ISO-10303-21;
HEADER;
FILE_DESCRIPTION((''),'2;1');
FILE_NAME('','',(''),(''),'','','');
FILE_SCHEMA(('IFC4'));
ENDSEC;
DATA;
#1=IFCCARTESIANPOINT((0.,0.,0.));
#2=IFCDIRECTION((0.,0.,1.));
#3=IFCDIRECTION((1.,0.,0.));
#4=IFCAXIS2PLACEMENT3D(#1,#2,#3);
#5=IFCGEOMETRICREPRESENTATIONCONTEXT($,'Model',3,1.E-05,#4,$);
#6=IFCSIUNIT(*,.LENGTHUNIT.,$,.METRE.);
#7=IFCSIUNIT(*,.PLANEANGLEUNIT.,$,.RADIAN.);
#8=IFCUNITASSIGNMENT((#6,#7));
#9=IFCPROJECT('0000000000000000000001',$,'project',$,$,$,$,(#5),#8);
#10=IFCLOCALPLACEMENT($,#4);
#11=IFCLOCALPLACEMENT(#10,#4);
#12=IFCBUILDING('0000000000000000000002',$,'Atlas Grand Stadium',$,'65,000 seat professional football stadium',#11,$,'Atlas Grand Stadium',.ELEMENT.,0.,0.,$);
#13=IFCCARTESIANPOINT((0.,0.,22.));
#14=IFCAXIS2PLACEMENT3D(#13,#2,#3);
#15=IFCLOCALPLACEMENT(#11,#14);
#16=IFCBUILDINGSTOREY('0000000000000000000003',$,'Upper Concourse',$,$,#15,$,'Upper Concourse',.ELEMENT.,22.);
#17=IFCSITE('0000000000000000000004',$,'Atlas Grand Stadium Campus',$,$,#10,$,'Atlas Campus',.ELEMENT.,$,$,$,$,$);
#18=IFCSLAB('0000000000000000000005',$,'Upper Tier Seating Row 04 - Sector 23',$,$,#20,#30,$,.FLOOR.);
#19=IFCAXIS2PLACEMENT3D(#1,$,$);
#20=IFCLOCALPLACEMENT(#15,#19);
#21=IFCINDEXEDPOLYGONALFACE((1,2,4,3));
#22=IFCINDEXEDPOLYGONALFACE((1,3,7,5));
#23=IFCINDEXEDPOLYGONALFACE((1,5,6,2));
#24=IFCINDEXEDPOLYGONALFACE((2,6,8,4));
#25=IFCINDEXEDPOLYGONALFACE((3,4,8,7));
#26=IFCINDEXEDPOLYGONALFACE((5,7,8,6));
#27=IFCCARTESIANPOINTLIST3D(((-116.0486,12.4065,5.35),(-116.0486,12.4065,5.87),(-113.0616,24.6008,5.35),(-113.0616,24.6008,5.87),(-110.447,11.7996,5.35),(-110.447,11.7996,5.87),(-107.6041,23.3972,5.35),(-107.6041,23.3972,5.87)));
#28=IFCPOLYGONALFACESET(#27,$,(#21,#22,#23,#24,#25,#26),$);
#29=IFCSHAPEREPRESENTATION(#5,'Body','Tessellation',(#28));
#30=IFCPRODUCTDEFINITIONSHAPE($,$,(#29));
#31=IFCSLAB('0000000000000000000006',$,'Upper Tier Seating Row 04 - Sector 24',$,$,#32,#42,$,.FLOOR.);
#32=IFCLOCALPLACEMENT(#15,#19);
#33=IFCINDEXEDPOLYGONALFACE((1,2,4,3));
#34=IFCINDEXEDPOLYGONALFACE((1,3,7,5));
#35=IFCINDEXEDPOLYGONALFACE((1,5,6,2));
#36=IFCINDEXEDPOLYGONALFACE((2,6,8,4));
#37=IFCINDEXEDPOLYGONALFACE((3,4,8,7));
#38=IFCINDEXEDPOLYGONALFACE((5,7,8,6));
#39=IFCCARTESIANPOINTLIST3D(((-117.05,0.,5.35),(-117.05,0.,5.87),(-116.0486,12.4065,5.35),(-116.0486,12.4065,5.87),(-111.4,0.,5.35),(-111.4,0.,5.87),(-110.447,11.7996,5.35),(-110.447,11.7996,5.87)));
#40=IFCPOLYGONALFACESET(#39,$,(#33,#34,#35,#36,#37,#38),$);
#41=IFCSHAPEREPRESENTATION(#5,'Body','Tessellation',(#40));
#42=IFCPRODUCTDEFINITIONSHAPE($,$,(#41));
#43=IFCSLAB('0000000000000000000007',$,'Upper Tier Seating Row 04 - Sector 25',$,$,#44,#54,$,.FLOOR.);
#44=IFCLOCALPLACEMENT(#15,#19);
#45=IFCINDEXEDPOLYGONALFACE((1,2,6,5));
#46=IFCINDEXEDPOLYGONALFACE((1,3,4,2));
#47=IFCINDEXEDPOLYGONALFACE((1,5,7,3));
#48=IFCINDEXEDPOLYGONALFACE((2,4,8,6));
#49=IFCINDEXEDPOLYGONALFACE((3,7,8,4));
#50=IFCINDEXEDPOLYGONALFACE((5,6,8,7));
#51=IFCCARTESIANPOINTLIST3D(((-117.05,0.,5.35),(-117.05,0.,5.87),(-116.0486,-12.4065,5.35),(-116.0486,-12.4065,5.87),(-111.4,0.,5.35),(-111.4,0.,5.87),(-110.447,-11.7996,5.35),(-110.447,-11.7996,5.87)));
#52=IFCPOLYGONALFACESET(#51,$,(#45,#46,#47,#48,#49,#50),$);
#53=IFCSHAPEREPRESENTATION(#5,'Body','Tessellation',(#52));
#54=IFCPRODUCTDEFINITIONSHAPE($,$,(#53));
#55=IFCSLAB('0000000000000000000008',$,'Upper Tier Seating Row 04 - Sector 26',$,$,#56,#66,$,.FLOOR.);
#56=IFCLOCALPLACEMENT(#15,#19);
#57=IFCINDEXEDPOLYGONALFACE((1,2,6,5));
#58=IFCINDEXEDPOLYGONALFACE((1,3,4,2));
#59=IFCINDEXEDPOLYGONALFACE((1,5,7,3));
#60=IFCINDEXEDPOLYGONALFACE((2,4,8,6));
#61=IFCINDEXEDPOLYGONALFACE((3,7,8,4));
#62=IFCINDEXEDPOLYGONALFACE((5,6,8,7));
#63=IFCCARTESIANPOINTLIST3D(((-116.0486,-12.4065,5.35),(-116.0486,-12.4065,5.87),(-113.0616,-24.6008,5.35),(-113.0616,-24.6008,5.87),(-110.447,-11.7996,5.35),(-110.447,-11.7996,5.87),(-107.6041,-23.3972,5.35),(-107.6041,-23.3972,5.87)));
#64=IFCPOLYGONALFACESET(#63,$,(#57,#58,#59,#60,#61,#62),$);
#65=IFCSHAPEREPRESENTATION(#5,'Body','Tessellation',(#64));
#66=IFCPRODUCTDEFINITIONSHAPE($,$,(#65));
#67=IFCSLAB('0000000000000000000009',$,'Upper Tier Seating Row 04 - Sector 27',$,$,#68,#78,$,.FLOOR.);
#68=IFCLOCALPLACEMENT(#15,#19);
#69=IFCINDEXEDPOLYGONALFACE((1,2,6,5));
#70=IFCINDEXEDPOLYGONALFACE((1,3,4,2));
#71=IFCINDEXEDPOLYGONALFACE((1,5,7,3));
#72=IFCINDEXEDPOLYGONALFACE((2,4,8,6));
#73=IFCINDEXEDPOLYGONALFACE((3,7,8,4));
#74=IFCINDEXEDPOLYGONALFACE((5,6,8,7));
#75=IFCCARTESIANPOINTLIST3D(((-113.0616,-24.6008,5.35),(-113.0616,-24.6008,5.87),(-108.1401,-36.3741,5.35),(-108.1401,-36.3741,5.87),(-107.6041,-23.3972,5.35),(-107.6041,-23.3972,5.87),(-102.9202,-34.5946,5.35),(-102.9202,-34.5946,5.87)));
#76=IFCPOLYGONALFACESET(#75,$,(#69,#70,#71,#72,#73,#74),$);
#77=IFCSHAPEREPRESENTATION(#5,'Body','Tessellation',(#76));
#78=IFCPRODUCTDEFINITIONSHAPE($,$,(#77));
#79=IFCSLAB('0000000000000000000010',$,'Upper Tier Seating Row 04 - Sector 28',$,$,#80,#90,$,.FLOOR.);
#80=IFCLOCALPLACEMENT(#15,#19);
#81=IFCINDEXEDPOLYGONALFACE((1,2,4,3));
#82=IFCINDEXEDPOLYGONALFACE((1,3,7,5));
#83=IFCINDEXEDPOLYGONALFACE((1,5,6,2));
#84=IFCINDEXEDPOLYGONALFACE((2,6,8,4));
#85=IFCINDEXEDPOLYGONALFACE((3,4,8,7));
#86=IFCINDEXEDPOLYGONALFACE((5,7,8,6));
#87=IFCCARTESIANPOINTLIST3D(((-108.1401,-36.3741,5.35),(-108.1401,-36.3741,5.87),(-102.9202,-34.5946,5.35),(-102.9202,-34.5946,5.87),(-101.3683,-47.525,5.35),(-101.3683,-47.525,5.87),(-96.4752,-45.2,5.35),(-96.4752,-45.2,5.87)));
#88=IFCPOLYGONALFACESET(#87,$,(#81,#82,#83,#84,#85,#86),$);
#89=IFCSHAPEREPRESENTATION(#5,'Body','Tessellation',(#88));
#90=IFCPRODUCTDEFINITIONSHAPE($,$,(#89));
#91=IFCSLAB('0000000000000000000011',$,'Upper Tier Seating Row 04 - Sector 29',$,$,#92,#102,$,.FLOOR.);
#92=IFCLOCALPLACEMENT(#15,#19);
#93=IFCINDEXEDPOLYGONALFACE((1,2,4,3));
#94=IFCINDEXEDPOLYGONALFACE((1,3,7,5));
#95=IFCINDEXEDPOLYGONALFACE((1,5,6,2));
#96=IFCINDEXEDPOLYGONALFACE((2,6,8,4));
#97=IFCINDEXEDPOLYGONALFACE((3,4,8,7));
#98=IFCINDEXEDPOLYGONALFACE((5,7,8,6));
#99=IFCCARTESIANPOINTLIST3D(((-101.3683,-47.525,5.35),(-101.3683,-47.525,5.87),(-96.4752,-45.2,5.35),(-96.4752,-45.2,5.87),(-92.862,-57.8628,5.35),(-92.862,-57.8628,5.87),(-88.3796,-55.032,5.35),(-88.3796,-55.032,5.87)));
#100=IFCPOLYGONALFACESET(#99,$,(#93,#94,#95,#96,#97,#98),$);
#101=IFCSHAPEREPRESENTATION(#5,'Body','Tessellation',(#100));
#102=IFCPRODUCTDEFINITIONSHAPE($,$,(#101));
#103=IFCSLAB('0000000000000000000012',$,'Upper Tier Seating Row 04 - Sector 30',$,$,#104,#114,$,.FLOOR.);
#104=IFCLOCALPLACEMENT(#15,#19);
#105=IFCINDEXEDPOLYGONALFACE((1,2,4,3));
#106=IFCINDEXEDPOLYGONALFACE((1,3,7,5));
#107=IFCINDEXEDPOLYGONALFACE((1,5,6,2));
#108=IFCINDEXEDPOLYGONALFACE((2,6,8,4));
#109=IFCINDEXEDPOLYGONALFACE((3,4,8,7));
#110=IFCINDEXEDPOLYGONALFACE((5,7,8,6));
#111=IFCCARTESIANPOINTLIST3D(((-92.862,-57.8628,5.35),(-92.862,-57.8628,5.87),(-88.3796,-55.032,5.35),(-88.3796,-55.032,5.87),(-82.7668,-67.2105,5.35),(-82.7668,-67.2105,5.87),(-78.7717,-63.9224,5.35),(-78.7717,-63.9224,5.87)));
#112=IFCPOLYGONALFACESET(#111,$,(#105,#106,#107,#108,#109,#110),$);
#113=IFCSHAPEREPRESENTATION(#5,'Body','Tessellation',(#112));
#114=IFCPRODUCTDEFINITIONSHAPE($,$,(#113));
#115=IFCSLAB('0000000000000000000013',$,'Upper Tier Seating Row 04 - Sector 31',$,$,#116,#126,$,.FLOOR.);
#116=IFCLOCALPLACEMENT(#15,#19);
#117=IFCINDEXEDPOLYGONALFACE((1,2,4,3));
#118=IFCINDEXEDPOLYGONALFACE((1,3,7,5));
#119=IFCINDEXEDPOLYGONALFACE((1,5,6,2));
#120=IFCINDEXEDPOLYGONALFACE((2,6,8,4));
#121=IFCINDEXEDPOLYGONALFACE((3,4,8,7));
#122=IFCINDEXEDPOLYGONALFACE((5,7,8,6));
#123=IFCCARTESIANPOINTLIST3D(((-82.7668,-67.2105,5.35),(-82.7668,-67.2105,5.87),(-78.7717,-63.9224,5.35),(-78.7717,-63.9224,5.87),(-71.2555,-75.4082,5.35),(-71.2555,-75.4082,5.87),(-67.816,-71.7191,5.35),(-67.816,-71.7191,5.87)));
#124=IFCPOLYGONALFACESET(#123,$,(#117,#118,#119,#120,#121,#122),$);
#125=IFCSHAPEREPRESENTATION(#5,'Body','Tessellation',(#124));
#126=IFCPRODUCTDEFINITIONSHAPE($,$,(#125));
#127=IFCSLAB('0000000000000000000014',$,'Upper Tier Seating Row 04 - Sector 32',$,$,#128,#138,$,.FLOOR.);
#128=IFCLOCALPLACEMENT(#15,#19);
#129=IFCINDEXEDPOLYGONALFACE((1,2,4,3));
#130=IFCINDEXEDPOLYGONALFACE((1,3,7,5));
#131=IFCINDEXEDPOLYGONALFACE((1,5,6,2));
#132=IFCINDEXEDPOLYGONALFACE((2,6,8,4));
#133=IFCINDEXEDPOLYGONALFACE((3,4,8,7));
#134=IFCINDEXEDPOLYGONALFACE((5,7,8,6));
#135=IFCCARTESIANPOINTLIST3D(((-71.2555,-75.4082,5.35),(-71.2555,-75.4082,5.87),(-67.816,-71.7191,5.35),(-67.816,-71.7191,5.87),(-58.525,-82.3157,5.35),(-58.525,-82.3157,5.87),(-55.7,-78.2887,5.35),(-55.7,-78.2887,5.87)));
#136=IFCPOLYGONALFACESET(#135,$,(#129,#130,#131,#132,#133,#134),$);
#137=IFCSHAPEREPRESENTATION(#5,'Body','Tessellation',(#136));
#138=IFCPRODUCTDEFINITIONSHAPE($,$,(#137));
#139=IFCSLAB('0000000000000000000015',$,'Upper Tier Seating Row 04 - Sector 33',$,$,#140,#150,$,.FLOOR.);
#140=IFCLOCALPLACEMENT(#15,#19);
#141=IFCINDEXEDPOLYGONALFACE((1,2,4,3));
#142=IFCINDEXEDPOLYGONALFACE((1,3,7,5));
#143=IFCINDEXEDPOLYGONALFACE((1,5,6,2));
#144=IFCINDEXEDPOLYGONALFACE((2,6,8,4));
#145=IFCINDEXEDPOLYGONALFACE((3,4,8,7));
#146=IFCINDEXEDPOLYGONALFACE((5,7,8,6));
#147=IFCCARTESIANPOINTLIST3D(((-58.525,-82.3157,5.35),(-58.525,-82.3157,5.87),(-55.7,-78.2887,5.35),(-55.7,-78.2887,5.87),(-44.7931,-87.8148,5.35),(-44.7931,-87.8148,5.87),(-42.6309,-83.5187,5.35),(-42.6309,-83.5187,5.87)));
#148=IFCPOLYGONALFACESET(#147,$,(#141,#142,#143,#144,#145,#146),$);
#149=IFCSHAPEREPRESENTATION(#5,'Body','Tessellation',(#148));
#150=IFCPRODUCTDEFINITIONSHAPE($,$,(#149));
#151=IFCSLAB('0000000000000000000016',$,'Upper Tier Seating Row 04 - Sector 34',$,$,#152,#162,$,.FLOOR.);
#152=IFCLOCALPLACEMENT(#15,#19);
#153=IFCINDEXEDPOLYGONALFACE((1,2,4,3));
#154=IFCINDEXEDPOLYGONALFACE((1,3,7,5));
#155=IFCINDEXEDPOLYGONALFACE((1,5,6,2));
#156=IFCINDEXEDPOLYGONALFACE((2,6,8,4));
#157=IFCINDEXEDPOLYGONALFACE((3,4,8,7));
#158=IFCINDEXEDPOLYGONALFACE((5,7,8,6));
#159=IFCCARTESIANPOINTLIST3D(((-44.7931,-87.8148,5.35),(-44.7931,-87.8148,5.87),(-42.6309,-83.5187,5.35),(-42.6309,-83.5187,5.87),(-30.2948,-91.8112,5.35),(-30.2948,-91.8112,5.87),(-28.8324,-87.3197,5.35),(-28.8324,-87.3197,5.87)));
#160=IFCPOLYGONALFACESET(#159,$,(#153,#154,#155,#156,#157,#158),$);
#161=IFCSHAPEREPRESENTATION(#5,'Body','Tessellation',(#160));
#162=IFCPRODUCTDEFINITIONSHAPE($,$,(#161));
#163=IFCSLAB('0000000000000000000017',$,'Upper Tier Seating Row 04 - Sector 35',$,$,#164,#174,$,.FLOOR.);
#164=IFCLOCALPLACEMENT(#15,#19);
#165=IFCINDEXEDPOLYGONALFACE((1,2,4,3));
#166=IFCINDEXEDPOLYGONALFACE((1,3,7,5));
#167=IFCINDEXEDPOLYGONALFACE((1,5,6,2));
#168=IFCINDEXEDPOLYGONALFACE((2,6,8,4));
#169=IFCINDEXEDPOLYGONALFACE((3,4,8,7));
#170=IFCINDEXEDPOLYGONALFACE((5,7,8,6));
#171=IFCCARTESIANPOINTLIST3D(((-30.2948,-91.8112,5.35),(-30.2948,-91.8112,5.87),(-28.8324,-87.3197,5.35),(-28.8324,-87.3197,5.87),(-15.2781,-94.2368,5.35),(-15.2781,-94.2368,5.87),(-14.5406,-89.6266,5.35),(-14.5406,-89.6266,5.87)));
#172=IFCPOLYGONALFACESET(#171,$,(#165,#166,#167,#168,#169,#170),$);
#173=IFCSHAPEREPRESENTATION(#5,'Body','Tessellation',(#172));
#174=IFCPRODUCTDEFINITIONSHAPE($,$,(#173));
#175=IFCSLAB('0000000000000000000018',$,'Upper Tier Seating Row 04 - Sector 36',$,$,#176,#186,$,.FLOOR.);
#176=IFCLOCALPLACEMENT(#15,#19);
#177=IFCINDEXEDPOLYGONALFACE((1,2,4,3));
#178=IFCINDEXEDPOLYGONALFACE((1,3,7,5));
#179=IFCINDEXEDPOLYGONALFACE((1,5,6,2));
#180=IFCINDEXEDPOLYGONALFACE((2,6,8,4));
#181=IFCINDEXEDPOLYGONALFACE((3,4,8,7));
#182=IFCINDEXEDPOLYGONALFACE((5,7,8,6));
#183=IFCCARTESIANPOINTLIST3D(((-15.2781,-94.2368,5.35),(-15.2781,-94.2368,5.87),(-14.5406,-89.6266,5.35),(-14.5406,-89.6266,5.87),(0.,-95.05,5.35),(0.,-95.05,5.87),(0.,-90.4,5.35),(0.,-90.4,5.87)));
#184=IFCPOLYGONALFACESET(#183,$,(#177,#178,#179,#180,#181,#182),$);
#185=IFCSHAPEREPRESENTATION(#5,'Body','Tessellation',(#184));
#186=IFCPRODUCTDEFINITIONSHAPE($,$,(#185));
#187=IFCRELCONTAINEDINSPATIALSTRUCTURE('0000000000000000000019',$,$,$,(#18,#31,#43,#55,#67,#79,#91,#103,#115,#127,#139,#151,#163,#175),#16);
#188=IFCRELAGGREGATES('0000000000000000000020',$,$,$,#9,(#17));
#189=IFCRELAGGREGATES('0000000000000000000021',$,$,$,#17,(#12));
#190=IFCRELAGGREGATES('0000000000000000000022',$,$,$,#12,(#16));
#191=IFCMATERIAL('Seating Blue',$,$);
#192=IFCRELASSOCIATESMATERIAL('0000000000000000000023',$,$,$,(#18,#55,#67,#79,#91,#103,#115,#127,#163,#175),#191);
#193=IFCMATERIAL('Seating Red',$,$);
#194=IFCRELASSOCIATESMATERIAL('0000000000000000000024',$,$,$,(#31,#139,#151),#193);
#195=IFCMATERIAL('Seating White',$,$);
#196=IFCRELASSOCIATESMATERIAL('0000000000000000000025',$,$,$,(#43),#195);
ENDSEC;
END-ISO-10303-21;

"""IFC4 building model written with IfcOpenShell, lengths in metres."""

from ifc_helpers import new_model, si_unit, frame, origin_with_axes, place, context, project, spatial, polyline, outline, extrude, material, element, save


model = new_model("IFC4")

# Units and contexts
model_context = context("Model", 3, precision=1e-05, world=origin_with_axes())
ifc_project = project(units=[si_unit("LENGTHUNIT", "METRE"), si_unit("PLANEANGLEUNIT", "RADIAN")], contexts=[model_context])

# Site, building, storey
site_placement = place(None, origin_with_axes())
site = spatial("IfcSite", under=ifc_project, at=site_placement, Name="Atlas Grand Stadium Campus", LongName="Atlas Campus", CompositionType="ELEMENT")
building_placement = place(site_placement, origin_with_axes())
building = spatial("IfcBuilding", under=site, at=building_placement, Name="Atlas Grand Stadium", ObjectType="65,000 seat professional football stadium", LongName="Atlas Grand Stadium", CompositionType="ELEMENT", ElevationOfRefHeight=0.0, ElevationOfTerrain=0.0)
storey_placement = place(building_placement, frame((0.0, 0.0, 22.0), z_axis=(0.0, 0.0, 1.0), x_axis=(1.0, 0.0, 0.0)))
storey = spatial("IfcBuildingStorey", under=building, at=storey_placement, Name="Upper Concourse", LongName="Upper Concourse", CompositionType="ELEMENT", Elevation=22.0)

# Slabs
ifc_material_1 = material(Name="Seating Blue")
slab_1_placement = place(storey_placement, frame((0.0, 0.0, 5.35), z_axis=(0.0, 0.0, 1.0), x_axis=(1.0, 0.0, 0.0)))
element("IfcSlab", 1, at=slab_1_placement, inside=storey, material=ifc_material_1, Name="Upper Tier Seating Row 04 - Sector 23", PredefinedType="FLOOR", context=model_context, shape_type="SweptSolid", body=[
    extrude(outline(polyline([(-113.0616, 24.6008), (-116.0486, 12.4065), (-110.447, 11.7996), (-107.6041, 23.3972), (-113.0616, 24.6008)])), origin_with_axes(), (0.0, 0.0, 1.0), 0.52),
])
ifc_material_2 = material(Name="Seating Red")
slab_2_placement = place(storey_placement, frame((0.0, 0.0, 5.35), z_axis=(0.0, 0.0, 1.0), x_axis=(1.0, 0.0, 0.0)))
element("IfcSlab", 2, at=slab_2_placement, inside=storey, material=ifc_material_2, Name="Upper Tier Seating Row 04 - Sector 24", PredefinedType="FLOOR", context=model_context, shape_type="SweptSolid", body=[
    extrude(outline(polyline([(-116.0486, 12.4065), (-117.05, 0.0), (-111.4, 0.0), (-110.447, 11.7996), (-116.0486, 12.4065)])), origin_with_axes(), (0.0, 0.0, 1.0), 0.52),
])
ifc_material_3 = material(Name="Seating White")
slab_3_placement = place(storey_placement, frame((0.0, 0.0, 5.35), z_axis=(0.0, 0.0, 1.0), x_axis=(1.0, 0.0, 0.0)))
element("IfcSlab", 3, at=slab_3_placement, inside=storey, material=ifc_material_3, Name="Upper Tier Seating Row 04 - Sector 25", PredefinedType="FLOOR", context=model_context, shape_type="SweptSolid", body=[
    extrude(outline(polyline([(-117.05, 0.0), (-116.0486, -12.4065), (-110.447, -11.7996), (-111.4, 0.0), (-117.05, 0.0)])), origin_with_axes(), (0.0, 0.0, 1.0), 0.52),
])
slab_4_placement = place(storey_placement, frame((0.0, 0.0, 5.35), z_axis=(0.0, 0.0, 1.0), x_axis=(1.0, 0.0, 0.0)))
element("IfcSlab", 4, at=slab_4_placement, inside=storey, material=ifc_material_1, Name="Upper Tier Seating Row 04 - Sector 26", PredefinedType="FLOOR", context=model_context, shape_type="SweptSolid", body=[
    extrude(outline(polyline([(-116.0486, -12.4065), (-113.0616, -24.6008), (-107.6041, -23.3972), (-110.447, -11.7996), (-116.0486, -12.4065)])), origin_with_axes(), (0.0, 0.0, 1.0), 0.52),
])
slab_5_placement = place(storey_placement, frame((0.0, 0.0, 5.35), z_axis=(0.0, 0.0, 1.0), x_axis=(1.0, 0.0, 0.0)))
element("IfcSlab", 5, at=slab_5_placement, inside=storey, material=ifc_material_1, Name="Upper Tier Seating Row 04 - Sector 27", PredefinedType="FLOOR", context=model_context, shape_type="SweptSolid", body=[
    extrude(outline(polyline([(-113.0616, -24.6008), (-108.1401, -36.3741), (-102.9202, -34.5946), (-107.6041, -23.3972), (-113.0616, -24.6008)])), origin_with_axes(), (0.0, 0.0, 1.0), 0.52),
])
slab_6_placement = place(storey_placement, frame((0.0, 0.0, 5.35), z_axis=(0.0, 0.0, 1.0), x_axis=(1.0, 0.0, 0.0)))
element("IfcSlab", 6, at=slab_6_placement, inside=storey, material=ifc_material_1, Name="Upper Tier Seating Row 04 - Sector 28", PredefinedType="FLOOR", context=model_context, shape_type="SweptSolid", body=[
    extrude(outline(polyline([(-108.1401, -36.3741), (-101.3683, -47.525), (-96.4752, -45.2), (-102.9202, -34.5946), (-108.1401, -36.3741)])), origin_with_axes(), (0.0, 0.0, 1.0), 0.52),
])
slab_7_placement = place(storey_placement, frame((0.0, 0.0, 5.35), z_axis=(0.0, 0.0, 1.0), x_axis=(1.0, 0.0, 0.0)))
element("IfcSlab", 7, at=slab_7_placement, inside=storey, material=ifc_material_1, Name="Upper Tier Seating Row 04 - Sector 29", PredefinedType="FLOOR", context=model_context, shape_type="SweptSolid", body=[
    extrude(outline(polyline([(-101.3683, -47.525), (-92.862, -57.8628), (-88.3796, -55.032), (-96.4752, -45.2), (-101.3683, -47.525)])), origin_with_axes(), (0.0, 0.0, 1.0), 0.52),
])
slab_8_placement = place(storey_placement, frame((0.0, 0.0, 5.35), z_axis=(0.0, 0.0, 1.0), x_axis=(1.0, 0.0, 0.0)))
element("IfcSlab", 8, at=slab_8_placement, inside=storey, material=ifc_material_1, Name="Upper Tier Seating Row 04 - Sector 30", PredefinedType="FLOOR", context=model_context, shape_type="SweptSolid", body=[
    extrude(outline(polyline([(-92.862, -57.8628), (-82.7669, -67.2105), (-78.7717, -63.9224), (-88.3796, -55.032), (-92.862, -57.8628)])), origin_with_axes(), (0.0, 0.0, 1.0), 0.52),
])
slab_9_placement = place(storey_placement, frame((0.0, 0.0, 5.35), z_axis=(0.0, 0.0, 1.0), x_axis=(1.0, 0.0, 0.0)))
element("IfcSlab", 9, at=slab_9_placement, inside=storey, material=ifc_material_1, Name="Upper Tier Seating Row 04 - Sector 31", PredefinedType="FLOOR", context=model_context, shape_type="SweptSolid", body=[
    extrude(outline(polyline([(-82.7669, -67.2105), (-71.2555, -75.4082), (-67.816, -71.7191), (-78.7717, -63.9224), (-82.7669, -67.2105)])), origin_with_axes(), (0.0, 0.0, 1.0), 0.52),
])
slab_10_placement = place(storey_placement, frame((0.0, 0.0, 5.35), z_axis=(0.0, 0.0, 1.0), x_axis=(1.0, 0.0, 0.0)))
element("IfcSlab", 10, at=slab_10_placement, inside=storey, material=ifc_material_1, Name="Upper Tier Seating Row 04 - Sector 32", PredefinedType="FLOOR", context=model_context, shape_type="SweptSolid", body=[
    extrude(outline(polyline([(-71.2555, -75.4082), (-58.525, -82.3157), (-55.7, -78.2887), (-67.816, -71.7191), (-71.2555, -75.4082)])), origin_with_axes(), (0.0, 0.0, 1.0), 0.52),
])
slab_11_placement = place(storey_placement, frame((0.0, 0.0, 5.35), z_axis=(0.0, 0.0, 1.0), x_axis=(1.0, 0.0, 0.0)))
element("IfcSlab", 11, at=slab_11_placement, inside=storey, material=ifc_material_2, Name="Upper Tier Seating Row 04 - Sector 33", PredefinedType="FLOOR", context=model_context, shape_type="SweptSolid", body=[
    extrude(outline(polyline([(-58.525, -82.3157), (-44.7931, -87.8148), (-42.6309, -83.5187), (-55.7, -78.2887), (-58.525, -82.3157)])), origin_with_axes(), (0.0, 0.0, 1.0), 0.52),
])
slab_12_placement = place(storey_placement, frame((0.0, 0.0, 5.35), z_axis=(0.0, 0.0, 1.0), x_axis=(1.0, 0.0, 0.0)))
element("IfcSlab", 12, at=slab_12_placement, inside=storey, material=ifc_material_2, Name="Upper Tier Seating Row 04 - Sector 34", PredefinedType="FLOOR", context=model_context, shape_type="SweptSolid", body=[
    extrude(outline(polyline([(-44.7931, -87.8148), (-30.2948, -91.8113), (-28.8324, -87.3197), (-42.6309, -83.5187), (-44.7931, -87.8148)])), origin_with_axes(), (0.0, 0.0, 1.0), 0.52),
])
slab_13_placement = place(storey_placement, frame((0.0, 0.0, 5.35), z_axis=(0.0, 0.0, 1.0), x_axis=(1.0, 0.0, 0.0)))
element("IfcSlab", 13, at=slab_13_placement, inside=storey, material=ifc_material_1, Name="Upper Tier Seating Row 04 - Sector 35", PredefinedType="FLOOR", context=model_context, shape_type="SweptSolid", body=[
    extrude(outline(polyline([(-30.2948, -91.8113), (-15.2781, -94.2368), (-14.5406, -89.6266), (-28.8324, -87.3197), (-30.2948, -91.8113)])), origin_with_axes(), (0.0, 0.0, 1.0), 0.52),
])
slab_14_placement = place(storey_placement, frame((0.0, 0.0, 5.35), z_axis=(0.0, 0.0, 1.0), x_axis=(1.0, 0.0, 0.0)))
element("IfcSlab", 14, at=slab_14_placement, inside=storey, material=ifc_material_1, Name="Upper Tier Seating Row 04 - Sector 36", PredefinedType="FLOOR", context=model_context, shape_type="SweptSolid", body=[
    extrude(outline(polyline([(-15.2781, -94.2368), (0.0, -95.05), (0.0, -90.4), (-14.5406, -89.6266), (-15.2781, -94.2368)])), origin_with_axes(), (0.0, 0.0, 1.0), 0.52),
])

save(model, "model.ifc")
